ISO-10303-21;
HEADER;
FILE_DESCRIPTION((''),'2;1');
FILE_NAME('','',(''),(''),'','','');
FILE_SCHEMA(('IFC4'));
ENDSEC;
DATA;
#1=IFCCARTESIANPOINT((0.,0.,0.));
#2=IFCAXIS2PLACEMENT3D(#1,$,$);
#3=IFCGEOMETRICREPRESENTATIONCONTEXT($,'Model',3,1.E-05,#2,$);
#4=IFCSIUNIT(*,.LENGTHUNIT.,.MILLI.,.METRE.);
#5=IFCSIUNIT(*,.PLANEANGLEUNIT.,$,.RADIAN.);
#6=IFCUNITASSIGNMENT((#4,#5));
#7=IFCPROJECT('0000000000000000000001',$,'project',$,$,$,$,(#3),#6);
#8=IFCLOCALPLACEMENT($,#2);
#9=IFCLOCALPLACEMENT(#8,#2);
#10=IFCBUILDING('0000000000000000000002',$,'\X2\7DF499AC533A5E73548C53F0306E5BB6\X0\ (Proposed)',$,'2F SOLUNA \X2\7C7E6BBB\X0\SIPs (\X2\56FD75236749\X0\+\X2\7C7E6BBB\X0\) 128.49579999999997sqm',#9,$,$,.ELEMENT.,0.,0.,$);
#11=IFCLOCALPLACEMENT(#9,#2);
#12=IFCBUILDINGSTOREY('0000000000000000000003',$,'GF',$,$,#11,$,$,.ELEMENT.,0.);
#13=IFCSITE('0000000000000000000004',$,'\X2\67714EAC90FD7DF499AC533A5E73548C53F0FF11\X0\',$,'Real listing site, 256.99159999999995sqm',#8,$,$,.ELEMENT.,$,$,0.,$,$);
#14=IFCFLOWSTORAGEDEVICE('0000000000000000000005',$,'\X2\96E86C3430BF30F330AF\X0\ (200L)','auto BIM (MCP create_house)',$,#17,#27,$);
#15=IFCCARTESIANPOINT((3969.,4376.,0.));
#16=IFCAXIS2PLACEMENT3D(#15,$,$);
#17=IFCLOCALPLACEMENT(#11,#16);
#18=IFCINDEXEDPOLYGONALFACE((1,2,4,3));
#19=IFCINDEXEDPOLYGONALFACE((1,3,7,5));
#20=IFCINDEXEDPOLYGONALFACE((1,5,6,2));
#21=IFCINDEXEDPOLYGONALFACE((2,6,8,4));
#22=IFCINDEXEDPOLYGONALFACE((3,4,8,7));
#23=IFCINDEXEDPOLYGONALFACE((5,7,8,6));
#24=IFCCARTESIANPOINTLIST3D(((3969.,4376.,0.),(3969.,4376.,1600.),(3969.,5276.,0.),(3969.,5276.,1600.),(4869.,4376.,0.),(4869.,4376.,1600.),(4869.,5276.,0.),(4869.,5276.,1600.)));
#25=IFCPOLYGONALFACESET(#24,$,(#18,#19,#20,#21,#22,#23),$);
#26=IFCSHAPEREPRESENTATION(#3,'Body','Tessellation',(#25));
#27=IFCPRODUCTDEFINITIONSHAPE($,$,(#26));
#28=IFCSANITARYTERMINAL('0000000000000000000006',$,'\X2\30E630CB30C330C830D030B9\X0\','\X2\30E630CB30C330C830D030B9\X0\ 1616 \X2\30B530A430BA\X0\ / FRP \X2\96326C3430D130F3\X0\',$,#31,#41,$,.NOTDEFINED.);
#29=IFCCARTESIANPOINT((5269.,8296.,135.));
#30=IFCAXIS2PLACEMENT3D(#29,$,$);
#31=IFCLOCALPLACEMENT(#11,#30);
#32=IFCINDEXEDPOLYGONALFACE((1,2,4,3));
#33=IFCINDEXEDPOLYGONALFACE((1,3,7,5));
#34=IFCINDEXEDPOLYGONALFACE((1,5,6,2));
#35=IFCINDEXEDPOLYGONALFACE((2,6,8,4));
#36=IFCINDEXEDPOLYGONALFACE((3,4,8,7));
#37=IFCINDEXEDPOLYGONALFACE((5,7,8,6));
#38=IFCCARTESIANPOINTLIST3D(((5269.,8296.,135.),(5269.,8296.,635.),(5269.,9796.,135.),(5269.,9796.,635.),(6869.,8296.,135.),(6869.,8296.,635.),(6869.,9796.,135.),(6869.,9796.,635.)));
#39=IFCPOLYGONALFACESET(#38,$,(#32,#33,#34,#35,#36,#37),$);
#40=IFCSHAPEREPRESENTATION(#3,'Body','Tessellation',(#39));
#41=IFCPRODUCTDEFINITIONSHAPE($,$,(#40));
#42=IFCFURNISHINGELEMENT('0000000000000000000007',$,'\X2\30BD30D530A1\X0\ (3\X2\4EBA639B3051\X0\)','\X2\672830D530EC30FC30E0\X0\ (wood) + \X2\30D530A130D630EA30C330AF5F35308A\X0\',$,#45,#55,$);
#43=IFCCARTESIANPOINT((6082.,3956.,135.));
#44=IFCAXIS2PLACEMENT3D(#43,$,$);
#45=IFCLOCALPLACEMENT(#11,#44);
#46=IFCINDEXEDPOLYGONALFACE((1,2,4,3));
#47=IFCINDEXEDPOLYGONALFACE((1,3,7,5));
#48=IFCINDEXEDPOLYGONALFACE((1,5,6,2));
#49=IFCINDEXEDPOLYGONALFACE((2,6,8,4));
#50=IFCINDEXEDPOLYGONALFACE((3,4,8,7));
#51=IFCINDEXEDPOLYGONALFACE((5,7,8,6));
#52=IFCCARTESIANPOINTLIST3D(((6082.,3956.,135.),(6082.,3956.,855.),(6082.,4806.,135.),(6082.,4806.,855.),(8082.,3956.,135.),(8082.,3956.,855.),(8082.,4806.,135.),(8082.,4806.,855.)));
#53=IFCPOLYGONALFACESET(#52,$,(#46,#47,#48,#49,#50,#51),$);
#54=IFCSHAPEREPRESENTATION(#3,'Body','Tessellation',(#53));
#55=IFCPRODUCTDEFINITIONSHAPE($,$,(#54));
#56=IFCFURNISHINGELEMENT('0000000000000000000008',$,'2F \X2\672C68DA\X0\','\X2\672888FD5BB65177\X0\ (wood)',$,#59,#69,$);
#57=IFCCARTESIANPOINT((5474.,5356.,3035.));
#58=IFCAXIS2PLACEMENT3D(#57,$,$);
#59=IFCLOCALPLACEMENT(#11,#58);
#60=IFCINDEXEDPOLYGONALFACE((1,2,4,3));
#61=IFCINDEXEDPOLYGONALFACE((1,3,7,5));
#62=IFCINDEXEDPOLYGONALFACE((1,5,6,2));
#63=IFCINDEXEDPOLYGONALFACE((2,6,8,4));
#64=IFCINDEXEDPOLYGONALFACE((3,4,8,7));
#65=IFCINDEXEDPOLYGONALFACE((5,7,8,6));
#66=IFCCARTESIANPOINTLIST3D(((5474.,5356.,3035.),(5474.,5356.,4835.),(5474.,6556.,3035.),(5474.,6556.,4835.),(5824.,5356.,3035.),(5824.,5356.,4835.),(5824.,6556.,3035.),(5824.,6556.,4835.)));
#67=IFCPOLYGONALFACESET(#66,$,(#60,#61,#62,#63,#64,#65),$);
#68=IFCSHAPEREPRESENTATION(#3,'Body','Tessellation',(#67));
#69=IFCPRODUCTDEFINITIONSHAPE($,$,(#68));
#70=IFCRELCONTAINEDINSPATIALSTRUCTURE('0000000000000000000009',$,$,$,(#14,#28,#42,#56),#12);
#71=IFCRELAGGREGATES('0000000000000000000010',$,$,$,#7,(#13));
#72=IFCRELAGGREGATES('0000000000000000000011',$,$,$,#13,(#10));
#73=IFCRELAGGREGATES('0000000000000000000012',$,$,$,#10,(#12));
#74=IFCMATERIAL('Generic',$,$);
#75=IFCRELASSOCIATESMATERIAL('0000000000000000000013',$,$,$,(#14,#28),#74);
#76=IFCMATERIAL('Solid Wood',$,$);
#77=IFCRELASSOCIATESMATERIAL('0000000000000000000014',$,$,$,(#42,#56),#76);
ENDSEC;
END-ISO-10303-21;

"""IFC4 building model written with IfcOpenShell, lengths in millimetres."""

from ifc_helpers import new_model, si_unit, frame, frame_2d, origin, place, context, project, spatial, rectangle, extrude, material, element, save


model = new_model("IFC4")

# Units and contexts
model_context = context("Model", 3, precision=1e-05, world=origin())
ifc_project = project(units=[si_unit("LENGTHUNIT", "METRE", prefix="MILLI"), si_unit("PLANEANGLEUNIT", "RADIAN")], contexts=[model_context])

# Site, building, storey
site_placement = place(None, origin())
site = spatial("IfcSite", under=ifc_project, at=site_placement, Name="東京都練馬区平和台１", ObjectType="Real listing site, 256.99159999999995sqm", CompositionType="ELEMENT", RefElevation=0.0)
building_placement = place(site_placement, origin())
building = spatial("IfcBuilding", under=site, at=building_placement, Name="練馬区平和台の家 (Proposed)", ObjectType="2F SOLUNA 籾殻SIPs (国産杉+籾殻) 128.49579999999997sqm", CompositionType="ELEMENT", ElevationOfRefHeight=0.0, ElevationOfTerrain=0.0)
storey_placement = place(building_placement, origin())
storey = spatial("IfcBuildingStorey", under=building, at=storey_placement, Name="GF", CompositionType="ELEMENT", Elevation=0.0)

# Shared definitions
ifc_material_1 = material(Name="Solid Wood")

# Shared definitions
ifc_material_2 = material(Name="Generic")

# Flow storage device
flow_storage_device_placement = place(storey_placement, frame((3969.0, 4376.0, 0.0)))
element("IfcFlowStorageDevice", 1, at=flow_storage_device_placement, inside=storey, material=ifc_material_2, Name="雨水タンク (200L)", Description="auto BIM (MCP create_house)", context=model_context, shape_type="SweptSolid", body=[
    extrude(rectangle(XDim=900.0, YDim=900.0, at=frame_2d((450.0, 450.0))), frame((3969.0, 4376.0, 0.0)), (0.0, 0.0, 1.0), 1600.0),
])

# Sanitary terminal
sanitary_terminal_placement = place(storey_placement, frame((5269.0, 8296.0, 135.0)))
element("IfcSanitaryTerminal", 2, at=sanitary_terminal_placement, inside=storey, material=ifc_material_2, Name="ユニットバス", Description="ユニットバス 1616 サイズ / FRP 防水パン", PredefinedType="NOTDEFINED", context=model_context, shape_type="SweptSolid", body=[
    extrude(rectangle(XDim=1600.0, YDim=1500.0, at=frame_2d((800.0, 750.0))), frame((5269.0, 8296.0, 135.0)), (0.0, 0.0, 1.0), 500.0),
])

# Furnishing elements
furnishing_1_placement = place(storey_placement, frame((6082.0, 3956.0, 135.0)))
element("IfcFurnishingElement", 3, at=furnishing_1_placement, inside=storey, material=ifc_material_1, Name="ソファ (3人掛け)", Description="木フレーム (wood) + ファブリック張り", context=model_context, shape_type="SweptSolid", body=[
    extrude(rectangle(XDim=2000.0, YDim=850.0, at=frame_2d((1000.0, 425.0))), frame((6082.0, 3956.0, 135.0)), (0.0, 0.0, 1.0), 720.0),
])
furnishing_2_placement = place(storey_placement, frame((5474.0, 5356.0, 3035.0)))
element("IfcFurnishingElement", 4, at=furnishing_2_placement, inside=storey, material=ifc_material_1, Name="2F 本棚", Description="木製家具 (wood)", context=model_context, shape_type="SweptSolid", body=[
    extrude(rectangle(XDim=350.0, YDim=1200.0, at=frame_2d((175.0, 600.0))), frame((5474.0, 5356.0, 3035.0)), (0.0, 0.0, 1.0), 1800.0),
])

save(model, "model.ifc")
